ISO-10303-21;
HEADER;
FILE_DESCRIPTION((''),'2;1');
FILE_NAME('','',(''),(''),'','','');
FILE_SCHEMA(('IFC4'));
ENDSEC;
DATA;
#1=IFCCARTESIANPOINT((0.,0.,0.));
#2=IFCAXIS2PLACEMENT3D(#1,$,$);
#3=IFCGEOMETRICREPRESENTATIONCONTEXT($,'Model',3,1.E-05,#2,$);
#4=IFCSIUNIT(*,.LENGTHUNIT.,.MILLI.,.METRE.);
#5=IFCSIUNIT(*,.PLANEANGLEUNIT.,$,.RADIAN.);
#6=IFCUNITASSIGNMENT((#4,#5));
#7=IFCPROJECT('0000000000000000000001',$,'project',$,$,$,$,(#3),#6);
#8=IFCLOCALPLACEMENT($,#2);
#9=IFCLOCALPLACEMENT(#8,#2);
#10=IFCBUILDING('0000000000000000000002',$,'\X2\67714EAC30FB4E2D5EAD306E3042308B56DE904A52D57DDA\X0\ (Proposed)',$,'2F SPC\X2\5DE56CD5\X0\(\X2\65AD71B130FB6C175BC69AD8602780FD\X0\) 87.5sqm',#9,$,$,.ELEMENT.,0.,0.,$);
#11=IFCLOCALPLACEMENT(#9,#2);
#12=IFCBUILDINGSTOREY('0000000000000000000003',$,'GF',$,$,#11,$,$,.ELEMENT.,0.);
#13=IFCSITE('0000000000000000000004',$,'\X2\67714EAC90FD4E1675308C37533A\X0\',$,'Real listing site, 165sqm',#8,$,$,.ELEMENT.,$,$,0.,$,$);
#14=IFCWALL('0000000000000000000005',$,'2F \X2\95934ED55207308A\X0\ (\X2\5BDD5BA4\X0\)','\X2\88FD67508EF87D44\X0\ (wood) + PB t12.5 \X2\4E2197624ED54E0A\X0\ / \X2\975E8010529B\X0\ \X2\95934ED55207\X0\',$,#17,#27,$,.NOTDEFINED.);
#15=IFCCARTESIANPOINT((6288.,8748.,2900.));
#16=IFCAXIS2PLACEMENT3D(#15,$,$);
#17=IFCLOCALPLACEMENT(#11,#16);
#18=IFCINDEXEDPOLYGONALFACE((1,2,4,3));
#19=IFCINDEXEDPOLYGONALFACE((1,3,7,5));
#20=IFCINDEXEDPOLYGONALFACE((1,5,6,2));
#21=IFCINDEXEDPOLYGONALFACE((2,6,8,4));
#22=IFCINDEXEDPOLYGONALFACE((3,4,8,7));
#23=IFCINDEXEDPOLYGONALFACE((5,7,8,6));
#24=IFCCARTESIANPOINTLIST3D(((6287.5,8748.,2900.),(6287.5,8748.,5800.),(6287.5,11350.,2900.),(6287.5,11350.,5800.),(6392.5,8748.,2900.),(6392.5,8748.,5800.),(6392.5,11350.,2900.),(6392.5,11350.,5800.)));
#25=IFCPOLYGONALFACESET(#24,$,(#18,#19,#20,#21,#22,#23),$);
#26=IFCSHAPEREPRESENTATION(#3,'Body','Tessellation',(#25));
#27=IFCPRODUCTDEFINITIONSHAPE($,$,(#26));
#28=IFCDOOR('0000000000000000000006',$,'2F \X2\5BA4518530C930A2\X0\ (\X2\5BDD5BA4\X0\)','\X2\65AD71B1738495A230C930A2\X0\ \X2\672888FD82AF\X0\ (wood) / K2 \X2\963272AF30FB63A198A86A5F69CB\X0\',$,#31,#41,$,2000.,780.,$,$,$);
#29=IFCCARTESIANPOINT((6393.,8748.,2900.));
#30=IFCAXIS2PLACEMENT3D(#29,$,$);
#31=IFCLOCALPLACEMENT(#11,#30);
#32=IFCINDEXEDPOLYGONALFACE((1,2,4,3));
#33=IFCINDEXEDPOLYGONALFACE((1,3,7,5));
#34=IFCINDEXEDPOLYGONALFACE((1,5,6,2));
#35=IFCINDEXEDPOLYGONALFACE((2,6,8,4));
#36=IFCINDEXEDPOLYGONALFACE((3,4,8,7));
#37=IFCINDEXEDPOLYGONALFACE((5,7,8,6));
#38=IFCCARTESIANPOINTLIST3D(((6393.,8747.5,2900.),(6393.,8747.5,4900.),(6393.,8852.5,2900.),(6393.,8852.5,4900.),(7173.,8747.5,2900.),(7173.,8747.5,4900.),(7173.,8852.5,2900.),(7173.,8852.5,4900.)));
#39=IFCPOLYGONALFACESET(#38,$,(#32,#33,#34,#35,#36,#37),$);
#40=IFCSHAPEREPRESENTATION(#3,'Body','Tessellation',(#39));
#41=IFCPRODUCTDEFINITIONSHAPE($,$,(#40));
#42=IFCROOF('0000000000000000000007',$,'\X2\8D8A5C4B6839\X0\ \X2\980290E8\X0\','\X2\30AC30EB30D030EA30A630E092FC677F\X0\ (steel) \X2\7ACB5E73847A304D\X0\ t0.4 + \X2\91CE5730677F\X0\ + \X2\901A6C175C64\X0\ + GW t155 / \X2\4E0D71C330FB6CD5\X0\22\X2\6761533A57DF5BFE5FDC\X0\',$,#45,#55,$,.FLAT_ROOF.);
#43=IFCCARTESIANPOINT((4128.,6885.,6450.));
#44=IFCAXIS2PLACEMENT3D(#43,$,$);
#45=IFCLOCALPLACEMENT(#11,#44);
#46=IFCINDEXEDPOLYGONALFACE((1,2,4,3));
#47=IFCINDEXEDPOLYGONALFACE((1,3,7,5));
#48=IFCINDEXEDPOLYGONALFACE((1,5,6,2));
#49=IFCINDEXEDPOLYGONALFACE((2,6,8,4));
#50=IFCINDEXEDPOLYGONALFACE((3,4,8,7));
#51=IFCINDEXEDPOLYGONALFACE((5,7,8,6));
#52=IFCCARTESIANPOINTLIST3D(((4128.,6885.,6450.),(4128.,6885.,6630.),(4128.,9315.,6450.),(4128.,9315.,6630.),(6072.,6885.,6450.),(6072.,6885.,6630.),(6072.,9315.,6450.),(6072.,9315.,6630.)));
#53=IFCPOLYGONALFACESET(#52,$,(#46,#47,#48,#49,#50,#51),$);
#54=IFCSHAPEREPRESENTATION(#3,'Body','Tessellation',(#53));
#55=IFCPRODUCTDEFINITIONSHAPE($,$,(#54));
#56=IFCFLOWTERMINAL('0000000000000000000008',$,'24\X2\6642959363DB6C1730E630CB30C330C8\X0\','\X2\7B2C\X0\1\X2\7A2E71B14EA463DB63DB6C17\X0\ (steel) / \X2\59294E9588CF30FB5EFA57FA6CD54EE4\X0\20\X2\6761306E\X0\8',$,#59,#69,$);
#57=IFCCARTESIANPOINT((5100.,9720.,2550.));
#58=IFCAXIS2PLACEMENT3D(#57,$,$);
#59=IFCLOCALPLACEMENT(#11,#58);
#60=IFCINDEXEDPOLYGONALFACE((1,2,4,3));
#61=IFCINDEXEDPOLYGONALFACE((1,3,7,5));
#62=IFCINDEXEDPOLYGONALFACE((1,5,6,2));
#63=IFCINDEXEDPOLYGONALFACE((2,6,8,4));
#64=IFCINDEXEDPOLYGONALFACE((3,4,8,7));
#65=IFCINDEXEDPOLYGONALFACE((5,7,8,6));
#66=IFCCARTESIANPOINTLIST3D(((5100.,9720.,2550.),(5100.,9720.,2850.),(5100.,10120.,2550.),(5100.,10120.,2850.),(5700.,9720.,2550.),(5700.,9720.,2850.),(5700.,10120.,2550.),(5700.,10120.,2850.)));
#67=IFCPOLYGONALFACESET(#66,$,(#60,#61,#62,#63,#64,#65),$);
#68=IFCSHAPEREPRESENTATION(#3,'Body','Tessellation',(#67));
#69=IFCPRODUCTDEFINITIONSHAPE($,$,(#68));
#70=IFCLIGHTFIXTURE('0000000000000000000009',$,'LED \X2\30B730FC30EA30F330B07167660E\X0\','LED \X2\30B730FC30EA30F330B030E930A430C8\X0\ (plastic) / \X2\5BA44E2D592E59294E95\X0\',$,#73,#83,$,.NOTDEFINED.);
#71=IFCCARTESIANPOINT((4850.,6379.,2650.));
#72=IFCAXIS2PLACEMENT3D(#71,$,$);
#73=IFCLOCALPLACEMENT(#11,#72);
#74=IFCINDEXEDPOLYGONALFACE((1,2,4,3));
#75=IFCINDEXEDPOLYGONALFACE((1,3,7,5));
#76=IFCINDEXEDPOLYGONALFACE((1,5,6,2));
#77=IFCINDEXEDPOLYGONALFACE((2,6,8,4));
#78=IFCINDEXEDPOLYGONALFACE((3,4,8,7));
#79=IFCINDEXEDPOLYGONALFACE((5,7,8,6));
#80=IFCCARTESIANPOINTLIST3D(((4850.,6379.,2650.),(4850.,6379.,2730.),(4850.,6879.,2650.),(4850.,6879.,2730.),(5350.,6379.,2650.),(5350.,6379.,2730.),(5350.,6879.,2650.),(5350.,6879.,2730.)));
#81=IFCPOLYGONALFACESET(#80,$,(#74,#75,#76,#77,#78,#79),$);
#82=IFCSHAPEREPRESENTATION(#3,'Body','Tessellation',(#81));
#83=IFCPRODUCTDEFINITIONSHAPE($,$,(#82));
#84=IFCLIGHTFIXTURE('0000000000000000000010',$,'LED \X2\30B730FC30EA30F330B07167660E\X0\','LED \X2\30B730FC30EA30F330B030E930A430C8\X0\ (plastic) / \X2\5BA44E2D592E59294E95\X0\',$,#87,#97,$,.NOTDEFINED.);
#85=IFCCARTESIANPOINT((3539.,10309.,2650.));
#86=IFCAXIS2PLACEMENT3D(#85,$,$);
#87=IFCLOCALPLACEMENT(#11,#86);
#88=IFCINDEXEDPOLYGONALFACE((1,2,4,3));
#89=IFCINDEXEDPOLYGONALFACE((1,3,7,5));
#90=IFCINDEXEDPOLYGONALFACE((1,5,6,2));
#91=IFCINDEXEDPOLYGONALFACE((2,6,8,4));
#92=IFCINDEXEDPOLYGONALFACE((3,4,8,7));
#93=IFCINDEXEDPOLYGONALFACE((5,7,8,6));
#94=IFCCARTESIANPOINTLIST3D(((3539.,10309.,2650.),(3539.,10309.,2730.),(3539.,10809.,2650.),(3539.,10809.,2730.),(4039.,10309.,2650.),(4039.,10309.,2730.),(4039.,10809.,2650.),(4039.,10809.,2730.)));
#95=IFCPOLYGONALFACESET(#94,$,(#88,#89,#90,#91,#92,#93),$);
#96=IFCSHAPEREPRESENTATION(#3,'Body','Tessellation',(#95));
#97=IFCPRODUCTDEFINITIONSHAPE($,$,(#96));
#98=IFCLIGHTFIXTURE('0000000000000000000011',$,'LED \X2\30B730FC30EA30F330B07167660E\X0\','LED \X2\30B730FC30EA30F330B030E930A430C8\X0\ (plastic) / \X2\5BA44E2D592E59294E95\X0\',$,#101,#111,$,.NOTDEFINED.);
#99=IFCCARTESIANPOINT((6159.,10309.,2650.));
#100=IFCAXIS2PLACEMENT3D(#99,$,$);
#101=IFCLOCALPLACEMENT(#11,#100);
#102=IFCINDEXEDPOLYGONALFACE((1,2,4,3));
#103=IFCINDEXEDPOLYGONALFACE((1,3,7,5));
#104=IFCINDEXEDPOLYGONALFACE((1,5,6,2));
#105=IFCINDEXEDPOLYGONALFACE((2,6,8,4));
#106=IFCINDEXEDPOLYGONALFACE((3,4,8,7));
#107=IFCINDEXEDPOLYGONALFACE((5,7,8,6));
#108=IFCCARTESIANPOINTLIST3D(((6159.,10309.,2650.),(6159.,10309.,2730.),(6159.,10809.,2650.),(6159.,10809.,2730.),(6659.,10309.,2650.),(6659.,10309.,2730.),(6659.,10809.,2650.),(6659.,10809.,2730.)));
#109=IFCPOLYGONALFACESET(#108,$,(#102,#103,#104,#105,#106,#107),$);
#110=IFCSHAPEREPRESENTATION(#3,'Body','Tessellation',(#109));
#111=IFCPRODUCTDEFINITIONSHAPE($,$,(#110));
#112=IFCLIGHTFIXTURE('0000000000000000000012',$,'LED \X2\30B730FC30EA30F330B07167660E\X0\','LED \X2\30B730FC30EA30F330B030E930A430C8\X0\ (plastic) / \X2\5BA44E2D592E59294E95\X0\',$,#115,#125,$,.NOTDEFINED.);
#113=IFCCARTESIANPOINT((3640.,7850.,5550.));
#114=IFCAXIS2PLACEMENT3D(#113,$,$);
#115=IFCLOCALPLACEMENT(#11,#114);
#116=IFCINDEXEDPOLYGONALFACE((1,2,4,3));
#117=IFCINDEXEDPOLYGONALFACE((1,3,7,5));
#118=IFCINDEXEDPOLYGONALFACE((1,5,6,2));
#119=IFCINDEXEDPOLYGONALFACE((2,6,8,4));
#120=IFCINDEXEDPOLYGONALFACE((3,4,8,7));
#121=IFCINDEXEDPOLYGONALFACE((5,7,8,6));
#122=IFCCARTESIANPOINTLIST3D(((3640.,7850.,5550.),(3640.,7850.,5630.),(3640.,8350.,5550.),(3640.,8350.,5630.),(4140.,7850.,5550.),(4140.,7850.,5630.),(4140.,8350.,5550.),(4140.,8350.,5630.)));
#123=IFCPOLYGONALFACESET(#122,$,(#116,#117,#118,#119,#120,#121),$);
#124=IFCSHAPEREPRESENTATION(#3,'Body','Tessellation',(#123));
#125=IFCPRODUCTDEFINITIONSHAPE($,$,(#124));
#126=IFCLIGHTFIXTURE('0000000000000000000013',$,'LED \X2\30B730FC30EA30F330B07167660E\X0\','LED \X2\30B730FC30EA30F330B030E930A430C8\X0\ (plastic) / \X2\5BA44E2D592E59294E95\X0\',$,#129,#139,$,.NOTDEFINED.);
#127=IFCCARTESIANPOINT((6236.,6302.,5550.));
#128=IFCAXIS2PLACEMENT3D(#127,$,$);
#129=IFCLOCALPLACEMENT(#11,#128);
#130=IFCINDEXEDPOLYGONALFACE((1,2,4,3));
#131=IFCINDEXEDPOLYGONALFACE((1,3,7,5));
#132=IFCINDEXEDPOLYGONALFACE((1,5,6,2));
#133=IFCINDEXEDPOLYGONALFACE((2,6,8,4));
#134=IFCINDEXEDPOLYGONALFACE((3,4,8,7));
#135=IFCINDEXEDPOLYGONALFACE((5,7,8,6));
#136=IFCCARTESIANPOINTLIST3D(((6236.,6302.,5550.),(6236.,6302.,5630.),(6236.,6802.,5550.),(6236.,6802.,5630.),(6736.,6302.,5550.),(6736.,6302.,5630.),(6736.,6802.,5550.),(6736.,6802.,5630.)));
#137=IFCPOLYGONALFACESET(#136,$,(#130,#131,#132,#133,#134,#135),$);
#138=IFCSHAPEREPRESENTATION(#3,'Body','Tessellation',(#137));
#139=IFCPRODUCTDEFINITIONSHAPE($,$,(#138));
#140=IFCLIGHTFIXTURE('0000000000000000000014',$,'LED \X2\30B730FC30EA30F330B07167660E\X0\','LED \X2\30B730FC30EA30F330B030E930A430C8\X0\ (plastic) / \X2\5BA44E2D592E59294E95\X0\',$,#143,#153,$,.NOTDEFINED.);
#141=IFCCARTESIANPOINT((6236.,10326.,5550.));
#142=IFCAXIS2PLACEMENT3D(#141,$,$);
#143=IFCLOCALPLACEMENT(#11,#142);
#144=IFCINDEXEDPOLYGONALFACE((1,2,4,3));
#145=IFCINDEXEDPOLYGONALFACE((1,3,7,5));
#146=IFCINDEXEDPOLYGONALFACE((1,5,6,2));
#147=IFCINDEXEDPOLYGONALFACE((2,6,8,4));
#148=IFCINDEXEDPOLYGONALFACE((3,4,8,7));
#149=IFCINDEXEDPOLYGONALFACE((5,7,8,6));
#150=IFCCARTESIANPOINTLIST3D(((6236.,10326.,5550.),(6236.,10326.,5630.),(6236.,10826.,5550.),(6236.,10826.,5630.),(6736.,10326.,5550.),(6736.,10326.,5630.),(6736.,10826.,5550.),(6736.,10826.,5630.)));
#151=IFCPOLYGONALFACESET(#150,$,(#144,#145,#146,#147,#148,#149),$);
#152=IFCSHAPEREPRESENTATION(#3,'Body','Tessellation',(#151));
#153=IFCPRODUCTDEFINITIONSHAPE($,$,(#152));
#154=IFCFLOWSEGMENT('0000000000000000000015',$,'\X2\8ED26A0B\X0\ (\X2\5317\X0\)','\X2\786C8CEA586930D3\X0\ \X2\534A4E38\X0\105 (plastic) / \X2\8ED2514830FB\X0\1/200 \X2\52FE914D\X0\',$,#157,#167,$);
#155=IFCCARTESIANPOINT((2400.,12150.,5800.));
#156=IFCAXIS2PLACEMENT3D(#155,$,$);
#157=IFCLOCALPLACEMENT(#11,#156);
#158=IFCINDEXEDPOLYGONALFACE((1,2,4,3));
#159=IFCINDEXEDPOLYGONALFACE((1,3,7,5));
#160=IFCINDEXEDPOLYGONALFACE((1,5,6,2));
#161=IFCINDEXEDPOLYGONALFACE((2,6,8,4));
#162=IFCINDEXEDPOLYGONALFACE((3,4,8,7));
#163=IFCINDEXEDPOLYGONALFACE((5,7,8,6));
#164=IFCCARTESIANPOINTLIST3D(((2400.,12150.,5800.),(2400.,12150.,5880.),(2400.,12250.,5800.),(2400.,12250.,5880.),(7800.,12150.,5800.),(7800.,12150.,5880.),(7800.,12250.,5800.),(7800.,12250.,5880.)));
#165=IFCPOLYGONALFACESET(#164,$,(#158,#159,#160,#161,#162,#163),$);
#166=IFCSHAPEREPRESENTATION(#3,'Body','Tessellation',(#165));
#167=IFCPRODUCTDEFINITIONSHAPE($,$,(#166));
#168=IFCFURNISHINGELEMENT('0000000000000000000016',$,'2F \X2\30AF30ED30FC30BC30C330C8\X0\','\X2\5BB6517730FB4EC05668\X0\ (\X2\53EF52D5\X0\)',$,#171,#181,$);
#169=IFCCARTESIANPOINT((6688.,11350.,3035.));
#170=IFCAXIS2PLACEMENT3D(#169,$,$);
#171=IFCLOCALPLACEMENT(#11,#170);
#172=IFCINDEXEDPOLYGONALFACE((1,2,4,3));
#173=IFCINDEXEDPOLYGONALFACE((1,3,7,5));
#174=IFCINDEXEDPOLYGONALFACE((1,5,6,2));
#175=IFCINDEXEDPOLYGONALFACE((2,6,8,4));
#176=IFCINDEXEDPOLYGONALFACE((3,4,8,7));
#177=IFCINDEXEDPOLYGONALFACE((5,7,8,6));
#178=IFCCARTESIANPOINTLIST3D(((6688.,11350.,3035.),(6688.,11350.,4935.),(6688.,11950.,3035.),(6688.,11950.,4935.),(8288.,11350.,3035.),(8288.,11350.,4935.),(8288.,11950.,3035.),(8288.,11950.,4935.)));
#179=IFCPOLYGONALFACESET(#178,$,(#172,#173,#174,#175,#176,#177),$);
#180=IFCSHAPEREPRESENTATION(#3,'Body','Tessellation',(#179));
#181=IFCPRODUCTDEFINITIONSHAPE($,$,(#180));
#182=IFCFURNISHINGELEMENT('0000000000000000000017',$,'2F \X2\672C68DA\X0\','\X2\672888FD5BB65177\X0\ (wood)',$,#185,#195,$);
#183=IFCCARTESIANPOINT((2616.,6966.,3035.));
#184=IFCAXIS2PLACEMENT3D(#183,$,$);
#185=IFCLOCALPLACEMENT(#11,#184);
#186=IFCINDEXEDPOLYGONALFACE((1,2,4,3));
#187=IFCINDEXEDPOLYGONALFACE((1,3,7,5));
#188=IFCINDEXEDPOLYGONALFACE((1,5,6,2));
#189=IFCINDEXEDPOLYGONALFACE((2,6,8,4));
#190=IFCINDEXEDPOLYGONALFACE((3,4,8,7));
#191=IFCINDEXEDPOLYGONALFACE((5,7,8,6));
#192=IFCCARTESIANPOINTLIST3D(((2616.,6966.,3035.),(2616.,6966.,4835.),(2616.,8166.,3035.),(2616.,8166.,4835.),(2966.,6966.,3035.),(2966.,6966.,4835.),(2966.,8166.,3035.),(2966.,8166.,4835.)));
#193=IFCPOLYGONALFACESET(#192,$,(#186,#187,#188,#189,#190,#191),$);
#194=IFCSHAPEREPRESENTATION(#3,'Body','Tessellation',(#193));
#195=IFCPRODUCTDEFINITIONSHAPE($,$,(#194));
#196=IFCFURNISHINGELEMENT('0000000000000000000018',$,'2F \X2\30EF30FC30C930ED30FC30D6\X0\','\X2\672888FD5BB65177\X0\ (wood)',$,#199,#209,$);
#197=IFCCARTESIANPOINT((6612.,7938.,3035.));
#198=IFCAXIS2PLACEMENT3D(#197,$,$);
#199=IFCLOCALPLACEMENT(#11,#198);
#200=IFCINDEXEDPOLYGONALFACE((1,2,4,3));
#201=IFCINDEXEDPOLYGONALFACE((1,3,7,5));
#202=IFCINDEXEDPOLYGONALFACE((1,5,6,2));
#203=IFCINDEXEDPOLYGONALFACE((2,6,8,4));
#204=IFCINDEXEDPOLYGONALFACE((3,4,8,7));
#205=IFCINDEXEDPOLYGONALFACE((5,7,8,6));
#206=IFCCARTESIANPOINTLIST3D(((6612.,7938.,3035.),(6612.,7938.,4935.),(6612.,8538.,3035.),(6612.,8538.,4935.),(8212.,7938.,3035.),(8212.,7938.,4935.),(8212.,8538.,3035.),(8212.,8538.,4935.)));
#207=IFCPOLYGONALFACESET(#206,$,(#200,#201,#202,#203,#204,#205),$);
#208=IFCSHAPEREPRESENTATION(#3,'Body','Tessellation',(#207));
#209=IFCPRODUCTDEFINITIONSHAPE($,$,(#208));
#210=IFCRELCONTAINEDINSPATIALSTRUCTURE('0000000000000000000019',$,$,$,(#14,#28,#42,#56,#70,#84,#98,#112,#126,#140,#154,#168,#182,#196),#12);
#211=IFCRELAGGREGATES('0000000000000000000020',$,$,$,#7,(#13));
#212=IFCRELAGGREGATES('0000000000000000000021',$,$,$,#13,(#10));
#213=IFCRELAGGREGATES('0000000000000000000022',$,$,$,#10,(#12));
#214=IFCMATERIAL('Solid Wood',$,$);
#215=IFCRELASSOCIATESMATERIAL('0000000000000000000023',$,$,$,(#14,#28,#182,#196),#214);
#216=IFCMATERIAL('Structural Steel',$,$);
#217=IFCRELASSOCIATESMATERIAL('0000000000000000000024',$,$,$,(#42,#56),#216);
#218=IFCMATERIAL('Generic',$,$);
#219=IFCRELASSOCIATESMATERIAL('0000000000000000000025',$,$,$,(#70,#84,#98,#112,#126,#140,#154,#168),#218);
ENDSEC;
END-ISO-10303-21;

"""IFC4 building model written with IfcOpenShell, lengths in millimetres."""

from ifc_helpers import new_model, si_unit, frame, frame_2d, origin, place, context, project, spatial, rectangle, extrude, material, element, save


model = new_model("IFC4")

# Units and contexts
model_context = context("Model", 3, precision=1e-05, world=origin())
ifc_project = project(units=[si_unit("LENGTHUNIT", "METRE", prefix="MILLI"), si_unit("PLANEANGLEUNIT", "RADIAN")], contexts=[model_context])

# Site, building, storey
site_placement = place(None, origin())
site = spatial("IfcSite", under=ifc_project, at=site_placement, Name="東京都世田谷区", ObjectType="Real listing site, 165sqm", CompositionType="ELEMENT", RefElevation=0.0)
building_placement = place(site_placement, origin())
building = spatial("IfcBuilding", under=site, at=building_placement, Name="東京・中庭のある回遊動線 (Proposed)", ObjectType="2F SPC工法(断熱・気密高性能) 87.5sqm", CompositionType="ELEMENT", ElevationOfRefHeight=0.0, ElevationOfTerrain=0.0)
storey_placement = place(building_placement, origin())
storey = spatial("IfcBuildingStorey", under=building, at=storey_placement, Name="GF", CompositionType="ELEMENT", Elevation=0.0)

# Shared definitions
ifc_material_1 = material(Name="Solid Wood")

# Wall
wall_1_placement = place(storey_placement, frame((6288.0, 8748.0, 2900.0)))
element("IfcWall", 1, at=wall_1_placement, inside=storey, material=ifc_material_1, Name="2F 間仕切り (寝室)", Description="製材軸組 (wood) + PB t12.5 両面仕上 / 非耐力 間仕切", PredefinedType="NOTDEFINED", context=model_context, shape_type="SweptSolid", body=[
    extrude(rectangle(XDim=105.0, YDim=2602.0, at=frame_2d((52.0, 1301.0))), frame((6288.0, 8748.0, 2900.0)), (0.0, 0.0, 1.0), 2900.0),
])

# Door
door_placement = place(storey_placement, frame((6393.0, 8748.0, 2900.0)))
element("IfcDoor", 2, at=door_placement, inside=storey, material=ifc_material_1, Name="2F 室内ドア (寝室)", Description="断熱玄関ドア 木製芯 (wood) / K2 防犯・採風機構", OverallHeight=2000.0, OverallWidth=780.0, context=model_context, shape_type="SweptSolid", body=[
    extrude(rectangle(XDim=780.0, YDim=105.0, at=frame_2d((390.0, 52.0))), frame((6393.0, 8748.0, 2900.0)), (0.0, 0.0, 1.0), 2000.0),
])

# Roof
ifc_material_2 = material(Name="Structural Steel")
roof_placement = place(storey_placement, frame((4128.0, 6885.0, 6450.0)))
element("IfcRoof", 3, at=roof_placement, inside=storey, material=ifc_material_2, Name="越屋根 頂部", Description="ガルバリウム鋼板 (steel) 立平葺き t0.4 + 野地板 + 通気層 + GW t155 / 不燃・法22条区域対応", PredefinedType="FLAT_ROOF", context=model_context, shape_type="SweptSolid", body=[
    extrude(rectangle(XDim=1944.0, YDim=2430.0, at=frame_2d((972.0, 1215.0))), frame((4128.0, 6885.0, 6450.0)), (0.0, 0.0, 1.0), 180.0),
])

# Flow terminal
flow_terminal_placement = place(storey_placement, frame((5100.0, 9720.0, 2550.0)))
element("IfcFlowTerminal", 4, at=flow_terminal_placement, inside=storey, material=ifc_material_2, Name="24時間換気ユニット", Description="第1種熱交換換気 (steel) / 天井裏・建基法令20条の8", context=model_context, shape_type="SweptSolid", body=[
    extrude(rectangle(XDim=600.0, YDim=400.0, at=frame_2d((300.0, 200.0))), frame((5100.0, 9720.0, 2550.0)), (0.0, 0.0, 1.0), 300.0),
])

# Light fixtures
ifc_material_3 = material(Name="Generic")
light_fixture_1_placement = place(storey_placement, frame((4850.0, 6379.0, 2650.0)))
element("IfcLightFixture", 5, at=light_fixture_1_placement, inside=storey, material=ifc_material_3, Name="LED シーリング照明", Description="LED シーリングライト (plastic) / 室中央天井", PredefinedType="NOTDEFINED", context=model_context, shape_type="SweptSolid", body=[
    extrude(rectangle(XDim=500.0, YDim=500.0, at=frame_2d((250.0, 250.0))), frame((4850.0, 6379.0, 2650.0)), (0.0, 0.0, 1.0), 80.0),
])
light_fixture_2_placement = place(storey_placement, frame((3539.0, 10309.0, 2650.0)))
element("IfcLightFixture", 6, at=light_fixture_2_placement, inside=storey, material=ifc_material_3, Name="LED シーリング照明", Description="LED シーリングライト (plastic) / 室中央天井", PredefinedType="NOTDEFINED", context=model_context, shape_type="SweptSolid", body=[
    extrude(rectangle(XDim=500.0, YDim=500.0, at=frame_2d((250.0, 250.0))), frame((3539.0, 10309.0, 2650.0)), (0.0, 0.0, 1.0), 80.0),
])
light_fixture_3_placement = place(storey_placement, frame((6159.0, 10309.0, 2650.0)))
element("IfcLightFixture", 7, at=light_fixture_3_placement, inside=storey, material=ifc_material_3, Name="LED シーリング照明", Description="LED シーリングライト (plastic) / 室中央天井", PredefinedType="NOTDEFINED", context=model_context, shape_type="SweptSolid", body=[
    extrude(rectangle(XDim=500.0, YDim=500.0, at=frame_2d((250.0, 250.0))), frame((6159.0, 10309.0, 2650.0)), (0.0, 0.0, 1.0), 80.0),
])
light_fixture_4_placement = place(storey_placement, frame((3640.0, 7850.0, 5550.0)))
element("IfcLightFixture", 8, at=light_fixture_4_placement, inside=storey, material=ifc_material_3, Name="LED シーリング照明", Description="LED シーリングライト (plastic) / 室中央天井", PredefinedType="NOTDEFINED", context=model_context, shape_type="SweptSolid", body=[
    extrude(rectangle(XDim=500.0, YDim=500.0, at=frame_2d((250.0, 250.0))), frame((3640.0, 7850.0, 5550.0)), (0.0, 0.0, 1.0), 80.0),
])
light_fixture_5_placement = place(storey_placement, frame((6236.0, 6302.0, 5550.0)))
element("IfcLightFixture", 9, at=light_fixture_5_placement, inside=storey, material=ifc_material_3, Name="LED シーリング照明", Description="LED シーリングライト (plastic) / 室中央天井", PredefinedType="NOTDEFINED", context=model_context, shape_type="SweptSolid", body=[
    extrude(rectangle(XDim=500.0, YDim=500.0, at=frame_2d((250.0, 250.0))), frame((6236.0, 6302.0, 5550.0)), (0.0, 0.0, 1.0), 80.0),
])
light_fixture_6_placement = place(storey_placement, frame((6236.0, 10326.0, 5550.0)))
element("IfcLightFixture", 10, at=light_fixture_6_placement, inside=storey, material=ifc_material_3, Name="LED シーリング照明", Description="LED シーリングライト (plastic) / 室中央天井", PredefinedType="NOTDEFINED", context=model_context, shape_type="SweptSolid", body=[
    extrude(rectangle(XDim=500.0, YDim=500.0, at=frame_2d((250.0, 250.0))), frame((6236.0, 10326.0, 5550.0)), (0.0, 0.0, 1.0), 80.0),
])

# Flow segment
flow_segment_placement = place(storey_placement, frame((2400.0, 12150.0, 5800.0)))
element("IfcFlowSegment", 11, at=flow_segment_placement, inside=storey, material=ifc_material_3, Name="軒樋 (北)", Description="硬質塩ビ 半丸105 (plastic) / 軒先・1/200 勾配", context=model_context, shape_type="SweptSolid", body=[
    extrude(rectangle(XDim=5400.0, YDim=100.0, at=frame_2d((2700.0, 50.0))), frame((2400.0, 12150.0, 5800.0)), (0.0, 0.0, 1.0), 80.0),
])

# Furnishing elements
furnishing_1_placement = place(storey_placement, frame((6688.0, 11350.0, 3035.0)))
element("IfcFurnishingElement", 12, at=furnishing_1_placement, inside=storey, material=ifc_material_3, Name="2F クローゼット", Description="家具・什器 (可動)", context=model_context, shape_type="SweptSolid", body=[
    extrude(rectangle(XDim=1600.0, YDim=600.0, at=frame_2d((800.0, 300.0))), frame((6688.0, 11350.0, 3035.0)), (0.0, 0.0, 1.0), 1900.0),
])
furnishing_2_placement = place(storey_placement, frame((2616.0, 6966.0, 3035.0)))
element("IfcFurnishingElement", 13, at=furnishing_2_placement, inside=storey, material=ifc_material_1, Name="2F 本棚", Description="木製家具 (wood)", context=model_context, shape_type="SweptSolid", body=[
    extrude(rectangle(XDim=350.0, YDim=1200.0, at=frame_2d((175.0, 600.0))), frame((2616.0, 6966.0, 3035.0)), (0.0, 0.0, 1.0), 1800.0),
])
furnishing_3_placement = place(storey_placement, frame((6612.0, 7938.0, 3035.0)))
element("IfcFurnishingElement", 14, at=furnishing_3_placement, inside=storey, material=ifc_material_1, Name="2F ワードローブ", Description="木製家具 (wood)", context=model_context, shape_type="SweptSolid", body=[
    extrude(rectangle(XDim=1600.0, YDim=600.0, at=frame_2d((800.0, 300.0))), frame((6612.0, 7938.0, 3035.0)), (0.0, 0.0, 1.0), 1900.0),
])

save(model, "model.ifc")
